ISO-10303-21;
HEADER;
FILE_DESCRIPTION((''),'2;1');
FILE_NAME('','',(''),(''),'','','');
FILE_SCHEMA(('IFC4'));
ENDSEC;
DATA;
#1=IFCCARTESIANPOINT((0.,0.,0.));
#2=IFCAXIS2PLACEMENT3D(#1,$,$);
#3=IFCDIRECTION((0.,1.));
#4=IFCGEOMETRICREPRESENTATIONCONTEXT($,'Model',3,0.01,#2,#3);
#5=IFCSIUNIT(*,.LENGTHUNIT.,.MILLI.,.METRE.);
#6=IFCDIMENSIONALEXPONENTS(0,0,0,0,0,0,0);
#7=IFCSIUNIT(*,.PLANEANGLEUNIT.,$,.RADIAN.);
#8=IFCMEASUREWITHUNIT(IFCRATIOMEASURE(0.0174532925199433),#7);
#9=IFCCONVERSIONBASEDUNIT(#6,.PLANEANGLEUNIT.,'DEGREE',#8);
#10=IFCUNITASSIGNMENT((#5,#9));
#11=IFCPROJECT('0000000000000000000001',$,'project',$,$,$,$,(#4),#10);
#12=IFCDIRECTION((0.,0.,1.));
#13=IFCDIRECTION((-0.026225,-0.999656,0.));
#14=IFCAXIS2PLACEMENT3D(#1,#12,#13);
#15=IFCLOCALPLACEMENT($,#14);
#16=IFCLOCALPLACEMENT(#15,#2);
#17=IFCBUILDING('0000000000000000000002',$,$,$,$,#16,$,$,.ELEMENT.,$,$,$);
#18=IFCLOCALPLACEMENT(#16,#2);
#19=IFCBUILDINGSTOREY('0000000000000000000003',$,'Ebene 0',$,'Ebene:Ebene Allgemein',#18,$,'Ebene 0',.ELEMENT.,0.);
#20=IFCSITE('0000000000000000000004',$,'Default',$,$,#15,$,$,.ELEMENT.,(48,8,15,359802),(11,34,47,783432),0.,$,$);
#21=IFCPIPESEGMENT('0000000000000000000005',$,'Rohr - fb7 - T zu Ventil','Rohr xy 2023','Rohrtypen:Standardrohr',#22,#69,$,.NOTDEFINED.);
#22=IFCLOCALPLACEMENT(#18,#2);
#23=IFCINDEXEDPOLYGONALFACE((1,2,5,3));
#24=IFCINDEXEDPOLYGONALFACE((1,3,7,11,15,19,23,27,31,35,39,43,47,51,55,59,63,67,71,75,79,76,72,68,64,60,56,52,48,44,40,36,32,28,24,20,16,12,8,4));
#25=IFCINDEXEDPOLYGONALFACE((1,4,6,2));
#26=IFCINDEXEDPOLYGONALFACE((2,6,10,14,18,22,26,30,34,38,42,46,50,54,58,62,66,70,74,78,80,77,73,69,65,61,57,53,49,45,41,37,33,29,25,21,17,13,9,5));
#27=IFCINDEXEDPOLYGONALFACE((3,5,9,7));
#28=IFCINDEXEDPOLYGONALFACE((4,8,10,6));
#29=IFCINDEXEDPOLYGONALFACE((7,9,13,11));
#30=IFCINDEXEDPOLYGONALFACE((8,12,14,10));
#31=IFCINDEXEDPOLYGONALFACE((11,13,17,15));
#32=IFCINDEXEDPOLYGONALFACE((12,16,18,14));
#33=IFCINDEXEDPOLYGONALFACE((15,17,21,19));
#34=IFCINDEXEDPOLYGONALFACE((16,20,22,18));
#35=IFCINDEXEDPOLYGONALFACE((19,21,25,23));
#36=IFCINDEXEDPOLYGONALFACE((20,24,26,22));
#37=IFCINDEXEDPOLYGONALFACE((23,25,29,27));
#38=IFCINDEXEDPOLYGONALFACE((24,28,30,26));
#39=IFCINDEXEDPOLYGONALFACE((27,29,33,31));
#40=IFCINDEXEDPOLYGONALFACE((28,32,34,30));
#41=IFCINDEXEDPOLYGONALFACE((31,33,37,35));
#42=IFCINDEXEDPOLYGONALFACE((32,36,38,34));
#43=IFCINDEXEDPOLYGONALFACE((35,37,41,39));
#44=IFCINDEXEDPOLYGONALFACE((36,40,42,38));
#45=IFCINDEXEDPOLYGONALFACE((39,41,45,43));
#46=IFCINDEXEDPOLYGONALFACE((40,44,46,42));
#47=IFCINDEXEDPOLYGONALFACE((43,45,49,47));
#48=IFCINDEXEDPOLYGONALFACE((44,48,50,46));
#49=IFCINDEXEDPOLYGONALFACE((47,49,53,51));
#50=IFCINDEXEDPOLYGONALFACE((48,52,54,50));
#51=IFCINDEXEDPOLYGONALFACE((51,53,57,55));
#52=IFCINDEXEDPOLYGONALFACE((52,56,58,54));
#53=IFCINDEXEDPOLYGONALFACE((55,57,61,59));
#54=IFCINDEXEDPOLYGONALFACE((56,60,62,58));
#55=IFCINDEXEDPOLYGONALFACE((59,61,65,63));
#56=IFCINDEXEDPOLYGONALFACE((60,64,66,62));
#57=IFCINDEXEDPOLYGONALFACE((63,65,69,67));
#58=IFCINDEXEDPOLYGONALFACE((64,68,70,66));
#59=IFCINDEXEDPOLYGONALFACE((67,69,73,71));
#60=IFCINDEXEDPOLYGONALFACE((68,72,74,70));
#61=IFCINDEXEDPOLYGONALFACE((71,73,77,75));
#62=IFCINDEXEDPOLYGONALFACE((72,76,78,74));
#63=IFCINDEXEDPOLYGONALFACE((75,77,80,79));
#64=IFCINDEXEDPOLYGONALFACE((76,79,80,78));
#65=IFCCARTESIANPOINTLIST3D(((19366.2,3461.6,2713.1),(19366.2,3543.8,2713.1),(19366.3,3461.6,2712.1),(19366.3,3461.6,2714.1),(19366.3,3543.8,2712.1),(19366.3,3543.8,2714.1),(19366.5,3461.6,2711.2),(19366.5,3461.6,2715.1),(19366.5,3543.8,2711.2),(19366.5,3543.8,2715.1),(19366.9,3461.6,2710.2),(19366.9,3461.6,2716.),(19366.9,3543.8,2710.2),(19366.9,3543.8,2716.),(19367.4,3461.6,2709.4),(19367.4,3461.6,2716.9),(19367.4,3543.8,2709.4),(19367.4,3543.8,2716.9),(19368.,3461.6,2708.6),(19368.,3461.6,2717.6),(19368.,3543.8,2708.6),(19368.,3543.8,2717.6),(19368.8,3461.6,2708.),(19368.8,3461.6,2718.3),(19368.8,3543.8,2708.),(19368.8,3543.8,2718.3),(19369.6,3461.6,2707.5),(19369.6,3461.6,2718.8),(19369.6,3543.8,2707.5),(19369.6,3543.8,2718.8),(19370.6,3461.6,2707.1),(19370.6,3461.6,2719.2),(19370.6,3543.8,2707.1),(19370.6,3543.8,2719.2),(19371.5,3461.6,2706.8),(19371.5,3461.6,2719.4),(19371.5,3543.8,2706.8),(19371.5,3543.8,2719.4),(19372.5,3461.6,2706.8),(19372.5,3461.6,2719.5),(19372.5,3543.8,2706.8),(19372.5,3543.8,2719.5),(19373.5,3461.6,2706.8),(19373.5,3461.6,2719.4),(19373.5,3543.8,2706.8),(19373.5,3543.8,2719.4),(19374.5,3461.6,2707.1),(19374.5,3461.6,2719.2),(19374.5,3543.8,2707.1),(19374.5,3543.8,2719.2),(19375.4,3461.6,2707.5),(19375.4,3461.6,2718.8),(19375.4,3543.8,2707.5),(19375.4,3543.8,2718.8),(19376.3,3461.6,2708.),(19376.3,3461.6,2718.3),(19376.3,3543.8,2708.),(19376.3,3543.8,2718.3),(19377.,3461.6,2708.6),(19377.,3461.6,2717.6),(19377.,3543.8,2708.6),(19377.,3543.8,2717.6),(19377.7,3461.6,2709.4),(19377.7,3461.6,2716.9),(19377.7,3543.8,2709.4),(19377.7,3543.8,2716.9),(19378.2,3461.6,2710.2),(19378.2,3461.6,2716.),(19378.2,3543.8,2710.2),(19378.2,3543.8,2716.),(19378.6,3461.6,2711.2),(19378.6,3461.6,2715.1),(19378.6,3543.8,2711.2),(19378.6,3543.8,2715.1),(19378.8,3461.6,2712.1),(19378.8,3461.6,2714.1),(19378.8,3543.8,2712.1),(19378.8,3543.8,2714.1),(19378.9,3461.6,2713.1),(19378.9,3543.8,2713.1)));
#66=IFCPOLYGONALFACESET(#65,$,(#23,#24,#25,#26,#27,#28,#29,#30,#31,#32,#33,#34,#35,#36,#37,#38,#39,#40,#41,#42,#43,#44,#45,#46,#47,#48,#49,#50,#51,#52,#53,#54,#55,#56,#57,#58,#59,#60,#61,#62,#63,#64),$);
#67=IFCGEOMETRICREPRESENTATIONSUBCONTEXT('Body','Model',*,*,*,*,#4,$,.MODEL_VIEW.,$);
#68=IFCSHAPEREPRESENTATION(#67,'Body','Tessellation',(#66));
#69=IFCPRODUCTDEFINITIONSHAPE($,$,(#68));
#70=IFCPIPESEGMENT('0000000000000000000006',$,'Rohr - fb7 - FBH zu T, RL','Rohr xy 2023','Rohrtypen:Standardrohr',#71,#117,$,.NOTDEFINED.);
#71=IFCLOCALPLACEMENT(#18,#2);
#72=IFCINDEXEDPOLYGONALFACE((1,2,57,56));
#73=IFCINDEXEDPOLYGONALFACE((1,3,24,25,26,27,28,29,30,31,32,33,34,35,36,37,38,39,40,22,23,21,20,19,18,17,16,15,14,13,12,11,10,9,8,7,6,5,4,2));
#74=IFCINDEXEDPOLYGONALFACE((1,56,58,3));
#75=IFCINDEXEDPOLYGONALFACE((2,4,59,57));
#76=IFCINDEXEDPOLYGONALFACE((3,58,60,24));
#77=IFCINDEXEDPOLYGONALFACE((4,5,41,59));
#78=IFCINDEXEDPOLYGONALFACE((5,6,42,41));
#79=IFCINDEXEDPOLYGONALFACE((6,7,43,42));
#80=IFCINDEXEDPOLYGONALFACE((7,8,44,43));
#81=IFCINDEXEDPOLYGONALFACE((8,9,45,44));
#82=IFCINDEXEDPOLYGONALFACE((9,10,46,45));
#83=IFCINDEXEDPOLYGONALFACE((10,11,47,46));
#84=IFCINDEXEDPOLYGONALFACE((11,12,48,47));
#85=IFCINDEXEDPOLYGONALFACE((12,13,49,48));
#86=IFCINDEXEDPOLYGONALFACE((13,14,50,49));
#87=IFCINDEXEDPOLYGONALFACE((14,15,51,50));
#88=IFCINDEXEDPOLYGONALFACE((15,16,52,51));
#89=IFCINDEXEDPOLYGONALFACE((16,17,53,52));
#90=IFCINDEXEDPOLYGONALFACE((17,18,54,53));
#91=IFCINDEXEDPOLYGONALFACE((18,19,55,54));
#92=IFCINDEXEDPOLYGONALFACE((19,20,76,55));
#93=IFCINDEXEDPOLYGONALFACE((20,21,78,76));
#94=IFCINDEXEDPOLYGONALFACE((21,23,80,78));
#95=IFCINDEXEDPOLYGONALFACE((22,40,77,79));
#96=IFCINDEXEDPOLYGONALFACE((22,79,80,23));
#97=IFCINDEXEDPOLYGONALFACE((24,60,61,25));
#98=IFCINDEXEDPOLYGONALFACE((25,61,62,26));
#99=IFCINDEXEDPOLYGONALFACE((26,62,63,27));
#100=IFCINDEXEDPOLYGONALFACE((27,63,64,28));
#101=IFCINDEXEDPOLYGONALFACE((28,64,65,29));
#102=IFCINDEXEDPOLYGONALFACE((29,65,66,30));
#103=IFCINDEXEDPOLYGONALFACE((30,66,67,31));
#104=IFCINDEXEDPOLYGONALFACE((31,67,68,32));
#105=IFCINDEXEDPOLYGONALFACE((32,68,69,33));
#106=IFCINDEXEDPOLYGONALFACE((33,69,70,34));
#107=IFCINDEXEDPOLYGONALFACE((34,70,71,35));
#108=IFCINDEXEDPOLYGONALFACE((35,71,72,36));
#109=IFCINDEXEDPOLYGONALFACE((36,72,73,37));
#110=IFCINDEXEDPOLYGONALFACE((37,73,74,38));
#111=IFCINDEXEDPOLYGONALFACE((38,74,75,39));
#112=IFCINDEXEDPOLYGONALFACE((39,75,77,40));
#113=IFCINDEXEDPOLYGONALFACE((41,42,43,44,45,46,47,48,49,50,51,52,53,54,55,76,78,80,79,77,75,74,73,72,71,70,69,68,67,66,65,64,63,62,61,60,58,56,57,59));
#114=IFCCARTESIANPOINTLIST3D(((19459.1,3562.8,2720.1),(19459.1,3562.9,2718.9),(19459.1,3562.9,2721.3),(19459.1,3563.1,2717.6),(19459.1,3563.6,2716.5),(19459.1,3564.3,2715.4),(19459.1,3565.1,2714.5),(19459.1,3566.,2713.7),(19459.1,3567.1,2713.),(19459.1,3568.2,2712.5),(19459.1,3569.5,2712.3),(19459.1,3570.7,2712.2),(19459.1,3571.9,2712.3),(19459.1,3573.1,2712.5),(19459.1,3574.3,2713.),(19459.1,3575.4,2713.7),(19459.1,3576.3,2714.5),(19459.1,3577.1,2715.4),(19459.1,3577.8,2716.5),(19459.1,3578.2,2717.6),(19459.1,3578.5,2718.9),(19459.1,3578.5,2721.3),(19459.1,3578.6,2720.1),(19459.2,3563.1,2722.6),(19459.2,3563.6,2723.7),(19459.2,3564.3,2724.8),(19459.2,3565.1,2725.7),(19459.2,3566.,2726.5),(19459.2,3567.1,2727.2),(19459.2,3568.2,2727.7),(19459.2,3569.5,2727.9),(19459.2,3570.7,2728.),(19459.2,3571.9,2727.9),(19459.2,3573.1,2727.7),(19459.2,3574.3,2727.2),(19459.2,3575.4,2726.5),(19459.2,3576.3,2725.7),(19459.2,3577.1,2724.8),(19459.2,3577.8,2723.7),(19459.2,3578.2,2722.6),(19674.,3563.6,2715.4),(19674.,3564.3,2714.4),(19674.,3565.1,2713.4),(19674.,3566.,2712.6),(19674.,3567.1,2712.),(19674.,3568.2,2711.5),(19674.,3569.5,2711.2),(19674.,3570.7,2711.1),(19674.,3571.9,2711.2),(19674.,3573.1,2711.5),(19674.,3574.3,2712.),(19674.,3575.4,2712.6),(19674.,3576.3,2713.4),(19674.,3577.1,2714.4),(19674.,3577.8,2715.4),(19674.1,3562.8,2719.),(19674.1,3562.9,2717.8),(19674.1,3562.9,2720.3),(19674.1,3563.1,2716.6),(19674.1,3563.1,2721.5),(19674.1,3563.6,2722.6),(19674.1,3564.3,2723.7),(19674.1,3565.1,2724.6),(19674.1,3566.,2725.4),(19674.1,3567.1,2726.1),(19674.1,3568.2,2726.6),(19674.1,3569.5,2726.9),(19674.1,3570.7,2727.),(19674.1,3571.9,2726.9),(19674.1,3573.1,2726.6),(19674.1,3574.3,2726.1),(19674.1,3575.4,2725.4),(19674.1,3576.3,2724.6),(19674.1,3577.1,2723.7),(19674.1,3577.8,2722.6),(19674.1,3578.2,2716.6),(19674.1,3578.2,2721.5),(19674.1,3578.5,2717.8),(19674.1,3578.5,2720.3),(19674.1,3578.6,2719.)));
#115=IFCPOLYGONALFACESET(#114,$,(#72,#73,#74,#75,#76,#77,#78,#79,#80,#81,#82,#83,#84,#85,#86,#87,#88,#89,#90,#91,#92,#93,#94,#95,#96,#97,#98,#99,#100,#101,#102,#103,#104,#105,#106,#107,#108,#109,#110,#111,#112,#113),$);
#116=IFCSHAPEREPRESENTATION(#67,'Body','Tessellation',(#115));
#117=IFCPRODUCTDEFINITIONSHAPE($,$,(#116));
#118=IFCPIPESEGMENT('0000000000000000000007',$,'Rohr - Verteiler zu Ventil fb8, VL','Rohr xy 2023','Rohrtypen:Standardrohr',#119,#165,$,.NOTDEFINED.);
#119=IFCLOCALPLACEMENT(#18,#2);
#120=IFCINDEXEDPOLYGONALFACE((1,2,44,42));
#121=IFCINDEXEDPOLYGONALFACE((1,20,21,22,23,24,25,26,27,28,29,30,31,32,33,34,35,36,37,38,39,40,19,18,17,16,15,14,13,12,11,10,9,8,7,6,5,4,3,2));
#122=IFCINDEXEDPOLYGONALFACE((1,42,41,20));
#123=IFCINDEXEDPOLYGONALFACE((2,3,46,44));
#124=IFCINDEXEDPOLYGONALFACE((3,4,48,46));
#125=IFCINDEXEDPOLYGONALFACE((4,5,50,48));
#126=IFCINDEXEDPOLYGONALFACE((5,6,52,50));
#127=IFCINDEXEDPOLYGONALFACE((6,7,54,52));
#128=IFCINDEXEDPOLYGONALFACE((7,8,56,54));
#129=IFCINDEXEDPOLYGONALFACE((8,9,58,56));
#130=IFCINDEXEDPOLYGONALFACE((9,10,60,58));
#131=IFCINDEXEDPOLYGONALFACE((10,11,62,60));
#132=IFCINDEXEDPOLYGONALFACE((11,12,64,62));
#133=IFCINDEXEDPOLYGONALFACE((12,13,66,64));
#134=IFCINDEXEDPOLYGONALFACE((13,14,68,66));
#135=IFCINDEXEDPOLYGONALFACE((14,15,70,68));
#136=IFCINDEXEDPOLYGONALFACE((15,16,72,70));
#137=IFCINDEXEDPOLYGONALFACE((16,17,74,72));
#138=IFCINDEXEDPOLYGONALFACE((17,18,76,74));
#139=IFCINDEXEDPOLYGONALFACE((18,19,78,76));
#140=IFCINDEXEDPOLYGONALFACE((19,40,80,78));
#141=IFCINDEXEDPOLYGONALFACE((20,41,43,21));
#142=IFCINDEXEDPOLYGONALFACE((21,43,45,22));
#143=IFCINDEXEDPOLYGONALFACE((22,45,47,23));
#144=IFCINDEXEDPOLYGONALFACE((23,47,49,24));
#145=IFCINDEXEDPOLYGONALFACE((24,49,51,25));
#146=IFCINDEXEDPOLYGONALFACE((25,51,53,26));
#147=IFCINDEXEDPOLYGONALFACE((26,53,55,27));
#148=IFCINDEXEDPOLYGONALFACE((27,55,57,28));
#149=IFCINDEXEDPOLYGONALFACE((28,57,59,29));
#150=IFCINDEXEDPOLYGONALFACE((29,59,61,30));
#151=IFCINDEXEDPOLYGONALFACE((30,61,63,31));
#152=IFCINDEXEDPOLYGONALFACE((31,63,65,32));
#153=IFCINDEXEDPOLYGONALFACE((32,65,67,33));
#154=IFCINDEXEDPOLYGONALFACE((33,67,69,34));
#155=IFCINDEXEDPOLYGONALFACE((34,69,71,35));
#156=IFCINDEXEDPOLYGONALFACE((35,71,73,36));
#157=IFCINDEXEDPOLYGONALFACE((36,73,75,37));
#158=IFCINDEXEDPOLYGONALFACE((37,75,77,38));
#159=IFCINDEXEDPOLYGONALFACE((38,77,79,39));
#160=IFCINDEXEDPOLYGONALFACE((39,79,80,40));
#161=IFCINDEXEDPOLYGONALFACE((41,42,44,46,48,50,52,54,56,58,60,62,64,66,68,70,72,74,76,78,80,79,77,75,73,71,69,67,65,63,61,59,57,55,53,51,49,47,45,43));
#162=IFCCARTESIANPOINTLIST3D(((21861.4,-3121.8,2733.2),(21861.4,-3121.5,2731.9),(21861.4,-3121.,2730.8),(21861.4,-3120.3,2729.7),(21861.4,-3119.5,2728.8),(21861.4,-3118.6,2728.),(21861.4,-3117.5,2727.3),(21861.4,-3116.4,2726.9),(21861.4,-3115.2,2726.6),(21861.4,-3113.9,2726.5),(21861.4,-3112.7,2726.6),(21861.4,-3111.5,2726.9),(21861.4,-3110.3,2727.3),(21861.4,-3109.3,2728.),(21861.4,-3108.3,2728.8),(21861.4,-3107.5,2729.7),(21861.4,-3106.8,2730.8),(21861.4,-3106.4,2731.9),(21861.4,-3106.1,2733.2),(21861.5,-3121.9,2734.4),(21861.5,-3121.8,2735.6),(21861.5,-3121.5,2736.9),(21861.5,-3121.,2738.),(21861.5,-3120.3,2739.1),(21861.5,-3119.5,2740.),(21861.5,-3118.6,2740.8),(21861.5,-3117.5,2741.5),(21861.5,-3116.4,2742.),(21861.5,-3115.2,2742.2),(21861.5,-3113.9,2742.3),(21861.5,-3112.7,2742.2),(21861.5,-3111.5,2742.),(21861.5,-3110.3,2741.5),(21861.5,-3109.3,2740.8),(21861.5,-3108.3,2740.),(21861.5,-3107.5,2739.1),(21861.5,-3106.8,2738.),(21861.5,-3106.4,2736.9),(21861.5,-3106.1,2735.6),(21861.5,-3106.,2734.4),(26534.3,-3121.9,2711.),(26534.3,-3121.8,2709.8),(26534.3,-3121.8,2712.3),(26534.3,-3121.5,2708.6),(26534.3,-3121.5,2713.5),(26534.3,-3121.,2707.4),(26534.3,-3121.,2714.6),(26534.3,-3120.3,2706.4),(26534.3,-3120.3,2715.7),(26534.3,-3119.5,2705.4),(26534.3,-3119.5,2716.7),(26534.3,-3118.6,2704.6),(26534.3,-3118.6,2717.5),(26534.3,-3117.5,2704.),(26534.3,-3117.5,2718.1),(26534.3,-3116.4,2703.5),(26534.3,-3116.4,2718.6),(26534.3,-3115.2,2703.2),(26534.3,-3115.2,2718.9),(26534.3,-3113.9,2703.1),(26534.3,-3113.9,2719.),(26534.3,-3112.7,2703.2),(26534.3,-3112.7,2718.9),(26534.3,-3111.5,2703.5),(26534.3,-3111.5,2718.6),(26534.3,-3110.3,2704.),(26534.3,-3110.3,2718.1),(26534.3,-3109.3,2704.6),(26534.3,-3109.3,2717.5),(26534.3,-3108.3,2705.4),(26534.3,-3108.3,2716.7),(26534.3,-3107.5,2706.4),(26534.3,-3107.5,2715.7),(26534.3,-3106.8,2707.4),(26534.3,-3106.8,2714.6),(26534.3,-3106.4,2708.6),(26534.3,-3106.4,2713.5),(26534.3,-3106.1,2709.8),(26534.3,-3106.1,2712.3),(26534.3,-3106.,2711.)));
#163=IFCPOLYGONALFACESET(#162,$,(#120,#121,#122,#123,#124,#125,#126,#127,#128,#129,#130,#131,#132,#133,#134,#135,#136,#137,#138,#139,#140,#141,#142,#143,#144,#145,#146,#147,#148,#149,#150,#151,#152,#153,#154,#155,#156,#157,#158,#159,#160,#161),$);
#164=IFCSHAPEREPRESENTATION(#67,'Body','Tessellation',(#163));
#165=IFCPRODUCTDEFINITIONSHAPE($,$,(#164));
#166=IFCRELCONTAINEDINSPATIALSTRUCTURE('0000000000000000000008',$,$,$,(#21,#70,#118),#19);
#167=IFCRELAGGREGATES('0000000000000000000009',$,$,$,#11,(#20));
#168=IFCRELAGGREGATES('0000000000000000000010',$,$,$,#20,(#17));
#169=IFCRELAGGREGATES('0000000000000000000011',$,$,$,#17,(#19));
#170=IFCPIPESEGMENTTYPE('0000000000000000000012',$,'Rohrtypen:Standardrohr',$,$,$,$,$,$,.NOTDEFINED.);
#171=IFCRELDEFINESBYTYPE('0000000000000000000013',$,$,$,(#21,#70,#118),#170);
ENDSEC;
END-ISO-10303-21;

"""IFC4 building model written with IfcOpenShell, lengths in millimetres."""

from ifc_helpers import new_model, entity, si_unit, converted_unit, direction, frame, origin, place, context, subcontext, project, spatial, indexed_curve, outline, extrude, type_object, element, save


model = new_model("IFC4")

# Units and contexts
model_context = context("Model", 3, precision=0.01, world=origin(), true_north=direction((0.0, 1.0)))
body_context = subcontext(model_context, "Body", "Model", "MODEL_VIEW")
ifc_project = project(units=[si_unit("LENGTHUNIT", "METRE", prefix="MILLI"), converted_unit("PLANEANGLEUNIT", "DEGREE", entity("IfcRatioMeasure", 0.0174532925199433), si_unit("PLANEANGLEUNIT", "RADIAN"), dimensions=[0, 0, 0, 0, 0, 0, 0])], contexts=[model_context])

# Site, building, storey
site_placement = place(None, frame((0.0, 0.0, 0.0), z_axis=(0.0, 0.0, 1.0), x_axis=(-0.026225, -0.999656, 0.0)))
site = spatial("IfcSite", under=ifc_project, at=site_placement, Name="Default", CompositionType="ELEMENT", RefLatitude=(48, 8, 15, 359802), RefLongitude=(11, 34, 47, 783432), RefElevation=0.0)
building_placement = place(site_placement, origin())
building = spatial("IfcBuilding", under=site, at=building_placement, CompositionType="ELEMENT")
storey_placement = place(building_placement, origin())
storey = spatial("IfcBuildingStorey", under=building, at=storey_placement, Name="Ebene 0", ObjectType="Ebene:Ebene Allgemein", LongName="Ebene 0", CompositionType="ELEMENT", Elevation=0.0)

# Pipe segments
pipe_segment_type = type_object("IfcPipeSegmentType", Name="Rohrtypen:Standardrohr", PredefinedType="NOTDEFINED")
pipe_segment_1_placement = place(storey_placement, origin())
element("IfcPipeSegment", 1, at=pipe_segment_1_placement, inside=storey, type_object=pipe_segment_type, Name="Rohr - fb7 - T zu Ventil", Description="Rohr xy 2023", ObjectType="Rohrtypen:Standardrohr", PredefinedType="NOTDEFINED", context=body_context, shape_type="SweptSolid", body=[
    extrude(outline(indexed_curve([(6.4, 0.0), (6.3, 1.0), (6.0, 2.0), (5.7, 2.9), (5.1, 3.7), (4.5, 4.5), (3.7, 5.1), (2.9, 5.7), (2.0, 6.0), (1.0, 6.3), (0.0, 6.4), (-1.0, 6.3), (-2.0, 6.0), (-2.9, 5.7), (-3.7, 5.1), (-4.5, 4.5), (-5.1, 3.7), (-5.7, 2.9), (-6.0, 2.0), (-6.3, 1.0), (-6.3, 0.0), (-6.3, -1.0), (-6.0, -2.0), (-5.7, -2.9), (-5.1, -3.7), (-4.5, -4.5), (-3.7, -5.1), (-2.9, -5.7), (-2.0, -6.0), (-1.0, -6.3), (0.0, -6.4), (1.0, -6.3), (2.0, -6.0), (2.9, -5.7), (3.7, -5.1), (4.5, -4.5), (5.1, -3.7), (5.7, -2.9), (6.0, -2.0), (6.3, -1.0), (6.4, 0.0)], self_intersect=False)), frame((19372.5, 3461.6, 2713.1), z_axis=(0.0, 1.0, 0.0), x_axis=(-1.0, 0.0, 0.0)), (0.0, 0.0, 1.0), 82.2),
])
pipe_segment_2_placement = place(storey_placement, origin())
element("IfcPipeSegment", 2, at=pipe_segment_2_placement, inside=storey, type_object=pipe_segment_type, Name="Rohr - fb7 - FBH zu T, RL", Description="Rohr xy 2023", ObjectType="Rohrtypen:Standardrohr", PredefinedType="NOTDEFINED", context=body_context, shape_type="SweptSolid", body=[
    extrude(outline(indexed_curve([(7.9, 0.0), (7.8, 1.2), (7.6, 2.5), (7.1, 3.6), (6.4, 4.7), (5.6, 5.6), (4.7, 6.4), (3.6, 7.1), (2.5, 7.6), (1.2, 7.8), (0.0, 7.9), (-1.2, 7.8), (-2.5, 7.6), (-3.6, 7.1), (-4.7, 6.4), (-5.6, 5.6), (-6.4, 4.7), (-7.1, 3.6), (-7.6, 2.5), (-7.8, 1.2), (-7.9, 0.0), (-7.8, -1.2), (-7.6, -2.5), (-7.1, -3.6), (-6.4, -4.7), (-5.6, -5.6), (-4.7, -6.4), (-3.6, -7.1), (-2.5, -7.6), (-1.2, -7.8), (0.0, -7.9), (1.2, -7.8), (2.5, -7.6), (3.6, -7.1), (4.7, -6.4), (5.6, -5.6), (6.4, -4.7), (7.1, -3.6), (7.6, -2.5), (7.8, -1.2), (7.9, 0.0)], self_intersect=False)), frame((19674.1, 3570.7, 2719.0), z_axis=(-0.999988, 0.0, 0.005), x_axis=(0.0, 1.0, 0.0)), (0.0, 0.0, 1.0), 214.9),
])
pipe_segment_3_placement = place(storey_placement, origin())
element("IfcPipeSegment", 3, at=pipe_segment_3_placement, inside=storey, type_object=pipe_segment_type, Name="Rohr - Verteiler zu Ventil fb8, VL", Description="Rohr xy 2023", ObjectType="Rohrtypen:Standardrohr", PredefinedType="NOTDEFINED", context=body_context, shape_type="SweptSolid", body=[
    extrude(outline(indexed_curve([(7.9, 0.0), (7.8, 1.2), (7.6, 2.5), (7.1, 3.6), (6.4, 4.7), (5.6, 5.6), (4.7, 6.4), (3.6, 7.1), (2.5, 7.6), (1.2, 7.8), (0.0, 7.9), (-1.2, 7.8), (-2.5, 7.6), (-3.6, 7.1), (-4.7, 6.4), (-5.6, 5.6), (-6.4, 4.7), (-7.1, 3.6), (-7.6, 2.5), (-7.8, 1.2), (-7.9, 0.0), (-7.8, -1.2), (-7.6, -2.5), (-7.1, -3.6), (-6.4, -4.7), (-5.6, -5.6), (-4.7, -6.4), (-3.6, -7.1), (-2.5, -7.6), (-1.2, -7.8), (0.0, -7.9), (1.2, -7.8), (2.5, -7.6), (3.6, -7.1), (4.7, -6.4), (5.6, -5.6), (6.4, -4.7), (7.1, -3.6), (7.6, -2.5), (7.8, -1.2), (7.9, 0.0)], self_intersect=False)), frame((26534.3, -3113.9, 2711.0), z_axis=(-0.999988, 0.0, 0.005), x_axis=(0.0, 1.0, 0.0)), (0.0, 0.0, 1.0), 4672.9),
])

save(model, "model.ifc")
